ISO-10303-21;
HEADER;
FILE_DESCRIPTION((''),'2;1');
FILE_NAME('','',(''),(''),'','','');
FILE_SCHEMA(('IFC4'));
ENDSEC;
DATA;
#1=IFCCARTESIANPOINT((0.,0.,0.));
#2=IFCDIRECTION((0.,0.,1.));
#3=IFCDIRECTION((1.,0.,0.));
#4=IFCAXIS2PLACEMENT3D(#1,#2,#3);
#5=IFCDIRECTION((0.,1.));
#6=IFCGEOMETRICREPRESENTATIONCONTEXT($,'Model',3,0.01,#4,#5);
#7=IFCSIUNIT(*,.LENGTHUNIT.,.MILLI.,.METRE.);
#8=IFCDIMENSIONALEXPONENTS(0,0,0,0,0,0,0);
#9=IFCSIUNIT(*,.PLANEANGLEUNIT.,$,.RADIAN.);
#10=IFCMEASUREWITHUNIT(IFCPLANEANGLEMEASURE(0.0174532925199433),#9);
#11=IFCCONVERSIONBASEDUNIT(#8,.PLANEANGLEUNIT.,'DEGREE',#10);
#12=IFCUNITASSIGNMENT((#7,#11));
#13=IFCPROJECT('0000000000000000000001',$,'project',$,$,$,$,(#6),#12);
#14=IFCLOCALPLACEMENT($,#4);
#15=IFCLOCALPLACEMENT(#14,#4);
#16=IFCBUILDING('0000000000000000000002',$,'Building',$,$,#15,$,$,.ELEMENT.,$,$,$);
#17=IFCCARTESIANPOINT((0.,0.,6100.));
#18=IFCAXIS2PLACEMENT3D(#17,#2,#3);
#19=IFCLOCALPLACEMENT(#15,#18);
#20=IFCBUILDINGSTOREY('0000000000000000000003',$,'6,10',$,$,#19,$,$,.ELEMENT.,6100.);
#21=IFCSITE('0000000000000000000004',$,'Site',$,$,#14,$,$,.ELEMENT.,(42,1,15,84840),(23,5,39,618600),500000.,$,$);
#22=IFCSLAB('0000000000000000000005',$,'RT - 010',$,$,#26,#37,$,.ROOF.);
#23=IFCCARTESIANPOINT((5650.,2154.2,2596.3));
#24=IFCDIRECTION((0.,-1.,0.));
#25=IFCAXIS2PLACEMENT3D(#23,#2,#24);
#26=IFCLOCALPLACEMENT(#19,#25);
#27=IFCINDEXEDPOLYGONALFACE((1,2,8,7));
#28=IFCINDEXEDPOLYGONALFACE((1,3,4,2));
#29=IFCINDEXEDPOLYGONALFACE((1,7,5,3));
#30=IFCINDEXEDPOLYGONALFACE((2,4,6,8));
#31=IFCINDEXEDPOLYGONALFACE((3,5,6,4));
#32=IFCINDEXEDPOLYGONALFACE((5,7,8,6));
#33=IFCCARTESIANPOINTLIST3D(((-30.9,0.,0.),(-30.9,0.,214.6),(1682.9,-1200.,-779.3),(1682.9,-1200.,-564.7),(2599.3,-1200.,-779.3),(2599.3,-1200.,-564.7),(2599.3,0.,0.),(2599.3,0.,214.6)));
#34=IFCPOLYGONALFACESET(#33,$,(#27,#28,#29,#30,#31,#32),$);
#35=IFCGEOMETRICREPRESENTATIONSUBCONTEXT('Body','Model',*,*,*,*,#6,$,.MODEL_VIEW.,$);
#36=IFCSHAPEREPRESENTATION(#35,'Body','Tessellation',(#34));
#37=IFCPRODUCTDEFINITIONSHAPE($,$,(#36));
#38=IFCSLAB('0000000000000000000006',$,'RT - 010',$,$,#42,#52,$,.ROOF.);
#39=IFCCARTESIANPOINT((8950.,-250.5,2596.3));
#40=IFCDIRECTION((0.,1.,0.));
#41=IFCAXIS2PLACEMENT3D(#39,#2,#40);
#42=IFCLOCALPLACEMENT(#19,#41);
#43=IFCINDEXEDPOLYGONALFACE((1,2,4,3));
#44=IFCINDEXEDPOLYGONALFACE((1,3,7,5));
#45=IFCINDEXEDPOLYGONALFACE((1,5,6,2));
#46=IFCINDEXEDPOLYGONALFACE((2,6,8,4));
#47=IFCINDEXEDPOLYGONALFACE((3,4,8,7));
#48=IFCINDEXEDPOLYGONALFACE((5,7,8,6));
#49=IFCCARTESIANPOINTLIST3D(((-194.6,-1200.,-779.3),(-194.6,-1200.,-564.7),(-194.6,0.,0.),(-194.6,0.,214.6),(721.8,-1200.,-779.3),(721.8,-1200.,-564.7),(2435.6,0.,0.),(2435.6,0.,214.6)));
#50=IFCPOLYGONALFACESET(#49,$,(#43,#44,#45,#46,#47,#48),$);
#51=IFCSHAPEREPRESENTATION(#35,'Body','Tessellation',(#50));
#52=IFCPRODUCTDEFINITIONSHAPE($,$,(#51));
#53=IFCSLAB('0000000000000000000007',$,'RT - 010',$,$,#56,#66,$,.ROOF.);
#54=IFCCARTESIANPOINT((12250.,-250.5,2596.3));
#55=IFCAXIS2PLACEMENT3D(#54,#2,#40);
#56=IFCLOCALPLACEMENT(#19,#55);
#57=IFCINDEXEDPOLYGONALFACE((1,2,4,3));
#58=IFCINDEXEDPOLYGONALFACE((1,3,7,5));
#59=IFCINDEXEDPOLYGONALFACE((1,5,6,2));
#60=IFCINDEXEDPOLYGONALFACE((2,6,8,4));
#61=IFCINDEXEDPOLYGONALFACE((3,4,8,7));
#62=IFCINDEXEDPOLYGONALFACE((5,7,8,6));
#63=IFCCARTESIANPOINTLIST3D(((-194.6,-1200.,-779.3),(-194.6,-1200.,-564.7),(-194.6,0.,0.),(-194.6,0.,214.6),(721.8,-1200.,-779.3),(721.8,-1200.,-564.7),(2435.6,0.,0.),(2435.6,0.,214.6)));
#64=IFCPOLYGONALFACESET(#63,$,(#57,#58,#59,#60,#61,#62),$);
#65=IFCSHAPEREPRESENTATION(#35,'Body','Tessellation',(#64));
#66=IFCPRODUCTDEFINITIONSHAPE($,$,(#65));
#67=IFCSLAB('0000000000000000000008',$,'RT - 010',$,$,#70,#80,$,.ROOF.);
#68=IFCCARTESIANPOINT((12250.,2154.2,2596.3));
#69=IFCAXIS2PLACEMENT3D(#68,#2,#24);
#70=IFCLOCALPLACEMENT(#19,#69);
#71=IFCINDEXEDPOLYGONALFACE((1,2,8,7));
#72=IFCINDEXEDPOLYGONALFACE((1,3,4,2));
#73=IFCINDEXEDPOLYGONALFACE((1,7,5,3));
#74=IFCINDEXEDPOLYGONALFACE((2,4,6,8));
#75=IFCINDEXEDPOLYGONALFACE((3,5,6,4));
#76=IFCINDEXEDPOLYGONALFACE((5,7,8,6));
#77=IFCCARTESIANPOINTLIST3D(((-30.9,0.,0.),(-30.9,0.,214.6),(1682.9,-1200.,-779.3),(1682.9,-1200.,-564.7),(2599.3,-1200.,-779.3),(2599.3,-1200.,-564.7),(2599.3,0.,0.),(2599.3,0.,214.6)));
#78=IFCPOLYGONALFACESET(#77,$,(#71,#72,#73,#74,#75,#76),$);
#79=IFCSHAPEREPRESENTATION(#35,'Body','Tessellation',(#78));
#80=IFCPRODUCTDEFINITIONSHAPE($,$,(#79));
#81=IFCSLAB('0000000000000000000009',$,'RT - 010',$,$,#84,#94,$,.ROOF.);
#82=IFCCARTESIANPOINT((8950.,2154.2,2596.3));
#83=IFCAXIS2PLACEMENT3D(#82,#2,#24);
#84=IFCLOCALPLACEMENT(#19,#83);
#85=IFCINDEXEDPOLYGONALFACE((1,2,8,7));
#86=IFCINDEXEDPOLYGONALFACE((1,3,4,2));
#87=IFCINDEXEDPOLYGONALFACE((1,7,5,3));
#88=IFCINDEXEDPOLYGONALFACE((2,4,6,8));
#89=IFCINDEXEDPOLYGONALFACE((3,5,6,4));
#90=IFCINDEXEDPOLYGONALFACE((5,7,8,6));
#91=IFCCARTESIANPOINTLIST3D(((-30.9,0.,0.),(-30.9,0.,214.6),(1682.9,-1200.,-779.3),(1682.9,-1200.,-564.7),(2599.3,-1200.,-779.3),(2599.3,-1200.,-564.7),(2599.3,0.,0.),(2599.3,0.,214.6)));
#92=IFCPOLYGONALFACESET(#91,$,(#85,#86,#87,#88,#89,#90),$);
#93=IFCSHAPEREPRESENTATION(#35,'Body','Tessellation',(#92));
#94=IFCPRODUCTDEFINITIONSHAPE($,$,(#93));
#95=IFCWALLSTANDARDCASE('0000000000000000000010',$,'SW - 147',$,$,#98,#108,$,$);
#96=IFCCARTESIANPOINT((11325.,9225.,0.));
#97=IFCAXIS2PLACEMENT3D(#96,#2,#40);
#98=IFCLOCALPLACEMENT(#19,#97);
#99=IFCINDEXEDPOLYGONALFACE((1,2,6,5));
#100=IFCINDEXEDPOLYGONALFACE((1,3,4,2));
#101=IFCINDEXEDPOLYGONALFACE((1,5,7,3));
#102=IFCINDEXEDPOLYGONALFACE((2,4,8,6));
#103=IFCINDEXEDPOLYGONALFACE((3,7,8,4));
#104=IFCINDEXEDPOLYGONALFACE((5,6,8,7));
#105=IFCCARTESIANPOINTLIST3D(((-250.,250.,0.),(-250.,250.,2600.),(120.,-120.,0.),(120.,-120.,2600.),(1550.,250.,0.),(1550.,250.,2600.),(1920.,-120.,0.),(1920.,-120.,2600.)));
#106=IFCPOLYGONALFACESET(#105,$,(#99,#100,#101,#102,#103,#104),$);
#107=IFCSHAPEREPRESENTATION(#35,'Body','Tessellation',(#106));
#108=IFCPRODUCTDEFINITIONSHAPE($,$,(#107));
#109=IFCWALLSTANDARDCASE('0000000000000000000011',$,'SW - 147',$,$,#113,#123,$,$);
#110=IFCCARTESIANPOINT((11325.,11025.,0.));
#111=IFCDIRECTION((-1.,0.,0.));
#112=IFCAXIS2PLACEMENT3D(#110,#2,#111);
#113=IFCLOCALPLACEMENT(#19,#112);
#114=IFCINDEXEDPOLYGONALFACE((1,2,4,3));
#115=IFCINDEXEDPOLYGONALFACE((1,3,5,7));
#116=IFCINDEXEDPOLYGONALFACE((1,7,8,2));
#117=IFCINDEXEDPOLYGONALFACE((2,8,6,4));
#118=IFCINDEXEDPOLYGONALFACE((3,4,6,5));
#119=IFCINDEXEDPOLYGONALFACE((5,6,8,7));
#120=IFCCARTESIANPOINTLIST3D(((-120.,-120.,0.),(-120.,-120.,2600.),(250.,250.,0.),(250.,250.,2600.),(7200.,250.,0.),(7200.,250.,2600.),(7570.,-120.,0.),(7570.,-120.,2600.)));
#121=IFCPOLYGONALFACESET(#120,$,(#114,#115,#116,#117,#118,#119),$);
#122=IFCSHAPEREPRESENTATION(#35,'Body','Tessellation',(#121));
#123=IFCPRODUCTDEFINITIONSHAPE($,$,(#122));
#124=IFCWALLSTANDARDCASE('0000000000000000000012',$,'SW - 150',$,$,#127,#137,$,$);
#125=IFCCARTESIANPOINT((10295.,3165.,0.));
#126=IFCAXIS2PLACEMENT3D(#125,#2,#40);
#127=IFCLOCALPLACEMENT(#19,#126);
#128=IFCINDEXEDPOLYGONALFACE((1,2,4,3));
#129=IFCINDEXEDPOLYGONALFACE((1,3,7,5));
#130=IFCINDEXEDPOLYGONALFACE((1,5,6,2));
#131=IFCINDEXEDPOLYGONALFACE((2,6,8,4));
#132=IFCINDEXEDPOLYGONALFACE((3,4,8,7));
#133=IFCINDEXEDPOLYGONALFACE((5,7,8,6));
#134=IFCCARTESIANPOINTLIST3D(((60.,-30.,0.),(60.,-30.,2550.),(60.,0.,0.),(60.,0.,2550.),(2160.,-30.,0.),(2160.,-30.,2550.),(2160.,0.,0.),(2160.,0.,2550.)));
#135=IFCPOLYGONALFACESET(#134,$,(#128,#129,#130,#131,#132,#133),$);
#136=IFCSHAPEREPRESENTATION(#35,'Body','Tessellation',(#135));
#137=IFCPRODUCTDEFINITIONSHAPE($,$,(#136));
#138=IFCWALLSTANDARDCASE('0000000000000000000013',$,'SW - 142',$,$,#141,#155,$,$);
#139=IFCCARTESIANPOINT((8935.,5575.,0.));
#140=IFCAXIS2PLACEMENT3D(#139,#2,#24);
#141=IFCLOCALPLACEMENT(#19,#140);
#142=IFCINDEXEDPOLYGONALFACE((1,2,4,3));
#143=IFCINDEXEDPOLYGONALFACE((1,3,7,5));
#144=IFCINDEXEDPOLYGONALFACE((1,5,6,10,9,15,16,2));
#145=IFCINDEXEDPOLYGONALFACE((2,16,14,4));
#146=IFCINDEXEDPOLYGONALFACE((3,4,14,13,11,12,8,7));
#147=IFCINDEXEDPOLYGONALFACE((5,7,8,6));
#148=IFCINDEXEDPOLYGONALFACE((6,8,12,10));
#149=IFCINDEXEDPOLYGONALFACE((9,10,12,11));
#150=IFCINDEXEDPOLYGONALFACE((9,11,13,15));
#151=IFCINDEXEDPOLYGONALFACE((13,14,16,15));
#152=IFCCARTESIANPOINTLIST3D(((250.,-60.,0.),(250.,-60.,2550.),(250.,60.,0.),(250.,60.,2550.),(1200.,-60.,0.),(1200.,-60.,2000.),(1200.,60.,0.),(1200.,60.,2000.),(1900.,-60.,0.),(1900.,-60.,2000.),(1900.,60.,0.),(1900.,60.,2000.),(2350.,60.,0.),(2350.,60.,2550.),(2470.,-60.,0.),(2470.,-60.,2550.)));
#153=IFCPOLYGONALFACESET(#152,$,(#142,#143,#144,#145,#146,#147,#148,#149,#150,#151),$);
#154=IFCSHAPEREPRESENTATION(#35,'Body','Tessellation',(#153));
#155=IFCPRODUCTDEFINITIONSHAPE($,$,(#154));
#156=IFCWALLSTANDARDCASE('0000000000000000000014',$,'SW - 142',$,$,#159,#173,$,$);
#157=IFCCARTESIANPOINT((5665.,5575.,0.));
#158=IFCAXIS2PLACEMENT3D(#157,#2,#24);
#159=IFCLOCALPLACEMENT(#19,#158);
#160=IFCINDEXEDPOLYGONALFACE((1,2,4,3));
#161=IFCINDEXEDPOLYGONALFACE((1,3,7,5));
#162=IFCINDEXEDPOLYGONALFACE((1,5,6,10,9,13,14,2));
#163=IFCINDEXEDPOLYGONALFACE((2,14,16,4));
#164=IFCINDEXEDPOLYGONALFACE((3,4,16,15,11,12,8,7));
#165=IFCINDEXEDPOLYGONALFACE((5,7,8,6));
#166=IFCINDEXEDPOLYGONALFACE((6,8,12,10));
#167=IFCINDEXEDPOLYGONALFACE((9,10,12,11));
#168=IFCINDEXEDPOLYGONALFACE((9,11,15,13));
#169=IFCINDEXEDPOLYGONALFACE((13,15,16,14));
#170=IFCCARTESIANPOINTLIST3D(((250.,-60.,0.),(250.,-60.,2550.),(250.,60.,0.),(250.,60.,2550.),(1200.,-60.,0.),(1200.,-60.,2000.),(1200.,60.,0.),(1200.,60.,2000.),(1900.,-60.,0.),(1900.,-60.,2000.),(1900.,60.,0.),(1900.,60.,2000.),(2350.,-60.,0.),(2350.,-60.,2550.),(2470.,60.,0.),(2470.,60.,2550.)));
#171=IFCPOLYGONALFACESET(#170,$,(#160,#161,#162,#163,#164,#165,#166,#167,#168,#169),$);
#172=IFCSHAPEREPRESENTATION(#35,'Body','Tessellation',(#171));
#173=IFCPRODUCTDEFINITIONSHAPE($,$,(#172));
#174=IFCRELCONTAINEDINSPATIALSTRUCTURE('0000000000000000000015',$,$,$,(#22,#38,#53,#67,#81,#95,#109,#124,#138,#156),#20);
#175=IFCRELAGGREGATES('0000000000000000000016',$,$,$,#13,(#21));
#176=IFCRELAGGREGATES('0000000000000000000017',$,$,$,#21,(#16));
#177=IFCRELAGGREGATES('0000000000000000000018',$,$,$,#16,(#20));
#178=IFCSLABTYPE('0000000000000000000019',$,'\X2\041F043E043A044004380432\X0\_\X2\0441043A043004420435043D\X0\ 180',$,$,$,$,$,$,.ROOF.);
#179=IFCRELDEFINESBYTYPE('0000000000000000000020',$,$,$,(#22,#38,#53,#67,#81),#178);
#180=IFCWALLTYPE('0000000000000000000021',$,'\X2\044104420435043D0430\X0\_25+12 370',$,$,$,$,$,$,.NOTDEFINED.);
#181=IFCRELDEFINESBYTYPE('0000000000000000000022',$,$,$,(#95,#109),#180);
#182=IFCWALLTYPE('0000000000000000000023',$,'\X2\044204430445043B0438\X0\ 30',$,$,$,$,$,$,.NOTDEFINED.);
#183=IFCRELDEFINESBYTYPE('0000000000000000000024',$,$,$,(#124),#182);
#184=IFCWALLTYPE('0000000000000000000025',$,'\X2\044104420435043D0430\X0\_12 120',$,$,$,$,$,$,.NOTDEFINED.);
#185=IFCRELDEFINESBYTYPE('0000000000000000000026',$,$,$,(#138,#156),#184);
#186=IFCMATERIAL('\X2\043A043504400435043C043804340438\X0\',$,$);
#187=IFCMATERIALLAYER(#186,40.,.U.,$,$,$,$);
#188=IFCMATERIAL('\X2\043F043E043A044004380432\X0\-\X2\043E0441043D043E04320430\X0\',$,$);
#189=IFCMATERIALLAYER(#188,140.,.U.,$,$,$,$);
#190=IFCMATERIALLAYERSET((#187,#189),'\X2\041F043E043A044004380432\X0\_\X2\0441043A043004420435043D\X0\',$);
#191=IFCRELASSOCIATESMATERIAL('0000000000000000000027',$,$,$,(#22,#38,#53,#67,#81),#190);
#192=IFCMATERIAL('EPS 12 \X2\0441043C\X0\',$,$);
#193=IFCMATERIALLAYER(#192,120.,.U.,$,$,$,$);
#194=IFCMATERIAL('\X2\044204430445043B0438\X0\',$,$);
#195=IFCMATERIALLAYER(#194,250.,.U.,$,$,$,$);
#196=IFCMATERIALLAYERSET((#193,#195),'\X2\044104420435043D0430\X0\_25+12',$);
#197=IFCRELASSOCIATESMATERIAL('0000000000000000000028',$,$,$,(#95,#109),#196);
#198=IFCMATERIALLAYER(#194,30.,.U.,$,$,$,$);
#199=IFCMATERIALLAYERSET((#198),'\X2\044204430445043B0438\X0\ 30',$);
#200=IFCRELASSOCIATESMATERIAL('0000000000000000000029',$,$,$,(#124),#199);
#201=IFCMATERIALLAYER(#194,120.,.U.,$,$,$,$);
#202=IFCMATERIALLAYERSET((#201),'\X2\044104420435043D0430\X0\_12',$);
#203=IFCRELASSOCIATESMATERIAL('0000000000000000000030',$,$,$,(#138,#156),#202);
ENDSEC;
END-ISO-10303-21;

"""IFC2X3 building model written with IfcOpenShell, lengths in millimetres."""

from ifc_helpers import new_model, entity, si_unit, converted_unit, direction, frame, origin_with_axes, origin_2d_with_axis, place, context, subcontext, project, spatial, polyline, rectangle, outline, extrude, material, layer, layer_set, layer_usage, type_object, element, save


model = new_model("IFC2X3")

# Units and contexts
model_context = context("Model", 3, precision=0.01, world=origin_with_axes(), true_north=direction((0.0, 1.0)))
body_context = subcontext(model_context, "Body", "Model", "MODEL_VIEW")
ifc_project = project(units=[si_unit("LENGTHUNIT", "METRE", prefix="MILLI"), converted_unit("PLANEANGLEUNIT", "DEGREE", entity("IfcPlaneAngleMeasure", 0.0174532925199433), si_unit("PLANEANGLEUNIT", "RADIAN"), dimensions=[0, 0, 0, 0, 0, 0, 0])], contexts=[model_context])

# Site, building, storey
site_placement = place(None, origin_with_axes())
site = spatial("IfcSite", under=ifc_project, at=site_placement, Name="Site", CompositionType="ELEMENT", RefLatitude=(42, 1, 15, 84840), RefLongitude=(23, 5, 39, 618600), RefElevation=500000.0)
building_placement = place(site_placement, origin_with_axes())
building = spatial("IfcBuilding", under=site, at=building_placement, Name="Building", CompositionType="ELEMENT")
storey_placement = place(building_placement, frame((0.0, 0.0, 6100.0), z_axis=(0.0, 0.0, 1.0), x_axis=(1.0, 0.0, 0.0)))
storey = spatial("IfcBuildingStorey", under=building, at=storey_placement, Name="6,10", CompositionType="ELEMENT", Elevation=6100.0)

# Slabs
ifc_material_1 = material(Name="керемиди")
ifc_layer_1 = layer(ifc_material_1, 40.0, ventilated="UNKNOWN")
ifc_material_2 = material(Name="покрив-основа")
ifc_layer_2 = layer(ifc_material_2, 140.0, ventilated="UNKNOWN")
ifc_layer_set_1 = layer_set([ifc_layer_1, ifc_layer_2], Name="Покрив_скатен")
ifc_layer_usage_1 = layer_usage(ifc_layer_set_1, "AXIS3", "NEGATIVE", 180.0)
slab_type = type_object("IfcSlabType", Name="Покрив_скатен 180", PredefinedType="ROOF")
slab_1_placement = place(storey_placement, frame((5650.0, 2154.2, 2596.3), z_axis=(0.0, 0.0, 1.0), x_axis=(0.0, -1.0, 0.0)))
element("IfcSlab", 1, at=slab_1_placement, inside=storey, type_object=slab_type, material=ifc_layer_usage_1, Name="RT - 010", PredefinedType="ROOF", context=body_context, shape_type="SweptSolid", body=[
    extrude(outline(polyline([(-30.9, 0.0), (1682.9, -1430.8), (2599.3, -1430.8), (2599.3, 0.0), (-30.9, 0.0)])), frame((0.0, 0.0, 0.0), z_axis=(0.0, -0.544639, 0.838671), x_axis=(1.0, 0.0, 0.0)), (0.0, 0.544639, 0.838671), 214.6),
])
ifc_layer_usage_2 = layer_usage(ifc_layer_set_1, "AXIS3", "NEGATIVE", 180.0)
slab_2_placement = place(storey_placement, frame((8950.0, -250.5, 2596.3), z_axis=(0.0, 0.0, 1.0), x_axis=(0.0, 1.0, 0.0)))
element("IfcSlab", 2, at=slab_2_placement, inside=storey, type_object=slab_type, material=ifc_layer_usage_2, Name="RT - 010", PredefinedType="ROOF", context=body_context, shape_type="SweptSolid", body=[
    extrude(outline(polyline([(2435.6, 0.0), (-194.6, 0.0), (-194.6, -1430.8), (721.8, -1430.8), (2435.6, 0.0)])), frame((0.0, 0.0, 0.0), z_axis=(0.0, -0.544639, 0.838671), x_axis=(1.0, 0.0, 0.0)), (0.0, 0.544639, 0.838671), 214.6),
])
ifc_layer_usage_3 = layer_usage(ifc_layer_set_1, "AXIS3", "NEGATIVE", 180.0)
slab_3_placement = place(storey_placement, frame((12250.0, -250.5, 2596.3), z_axis=(0.0, 0.0, 1.0), x_axis=(0.0, 1.0, 0.0)))
element("IfcSlab", 3, at=slab_3_placement, inside=storey, type_object=slab_type, material=ifc_layer_usage_3, Name="RT - 010", PredefinedType="ROOF", context=body_context, shape_type="SweptSolid", body=[
    extrude(outline(polyline([(2435.6, 0.0), (-194.6, 0.0), (-194.6, -1430.8), (721.8, -1430.8), (2435.6, 0.0)])), frame((0.0, 0.0, 0.0), z_axis=(0.0, -0.544639, 0.838671), x_axis=(1.0, 0.0, 0.0)), (0.0, 0.544639, 0.838671), 214.6),
])
ifc_layer_usage_4 = layer_usage(ifc_layer_set_1, "AXIS3", "NEGATIVE", 180.0)
slab_4_placement = place(storey_placement, frame((12250.0, 2154.2, 2596.3), z_axis=(0.0, 0.0, 1.0), x_axis=(0.0, -1.0, 0.0)))
element("IfcSlab", 4, at=slab_4_placement, inside=storey, type_object=slab_type, material=ifc_layer_usage_4, Name="RT - 010", PredefinedType="ROOF", context=body_context, shape_type="SweptSolid", body=[
    extrude(outline(polyline([(-30.9, 0.0), (1682.9, -1430.8), (2599.3, -1430.8), (2599.3, 0.0), (-30.9, 0.0)])), frame((0.0, 0.0, 0.0), z_axis=(0.0, -0.544639, 0.838671), x_axis=(1.0, 0.0, 0.0)), (0.0, 0.544639, 0.838671), 214.6),
])
ifc_layer_usage_5 = layer_usage(ifc_layer_set_1, "AXIS3", "NEGATIVE", 180.0)
slab_5_placement = place(storey_placement, frame((8950.0, 2154.2, 2596.3), z_axis=(0.0, 0.0, 1.0), x_axis=(0.0, -1.0, 0.0)))
element("IfcSlab", 5, at=slab_5_placement, inside=storey, type_object=slab_type, material=ifc_layer_usage_5, Name="RT - 010", PredefinedType="ROOF", context=body_context, shape_type="SweptSolid", body=[
    extrude(outline(polyline([(-30.9, 0.0), (1682.9, -1430.8), (2599.3, -1430.8), (2599.3, 0.0), (-30.9, 0.0)])), frame((0.0, 0.0, 0.0), z_axis=(0.0, -0.544639, 0.838671), x_axis=(1.0, 0.0, 0.0)), (0.0, 0.544639, 0.838671), 214.6),
])

# Shared definitions
ifc_material_3 = material(Name="EPS 12 см")
ifc_layer_3 = layer(ifc_material_3, 120.0, ventilated="UNKNOWN")
ifc_material_4 = material(Name="тухли")
ifc_layer_4 = layer(ifc_material_4, 250.0, ventilated="UNKNOWN")
ifc_layer_set_2 = layer_set([ifc_layer_3, ifc_layer_4], Name="стена_25+12")
wall_type_1 = type_object("IfcWallType", Name="стена_25+12 370", PredefinedType="NOTDEFINED")

# Walls
ifc_layer_usage_6 = layer_usage(ifc_layer_set_2, "AXIS2", "POSITIVE", -120.0)
wall_1_placement = place(storey_placement, frame((11325.0, 9225.0, 0.0), z_axis=(0.0, 0.0, 1.0), x_axis=(0.0, 1.0, 0.0)))
element("IfcWallStandardCase", 6, at=wall_1_placement, inside=storey, type_object=wall_type_1, material=ifc_layer_usage_6, Name="SW - 147", context=body_context, shape_type="SweptSolid", body=[
    extrude(outline(polyline([(120.0, -120.0), (1920.0, -120.0), (1550.0, 250.0), (-250.0, 250.0), (120.0, -120.0)])), origin_with_axes(), (0.0, 0.0, 1.0), 2600.0),
])
ifc_layer_usage_7 = layer_usage(ifc_layer_set_2, "AXIS2", "POSITIVE", -120.0)
wall_2_placement = place(storey_placement, frame((11325.0, 11025.0, 0.0), z_axis=(0.0, 0.0, 1.0), x_axis=(-1.0, 0.0, 0.0)))
element("IfcWallStandardCase", 7, at=wall_2_placement, inside=storey, type_object=wall_type_1, material=ifc_layer_usage_7, Name="SW - 147", context=body_context, shape_type="SweptSolid", body=[
    extrude(outline(polyline([(-120.0, -120.0), (7570.0, -120.0), (7200.0, 250.0), (250.0, 250.0), (-120.0, -120.0)])), origin_with_axes(), (0.0, 0.0, 1.0), 2600.0),
])
ifc_layer_5 = layer(ifc_material_4, 30.0, ventilated="UNKNOWN")
ifc_layer_set_3 = layer_set([ifc_layer_5], Name="тухли 30")
ifc_layer_usage_8 = layer_usage(ifc_layer_set_3, "AXIS2", "NEGATIVE", 0.0)
wall_type_2 = type_object("IfcWallType", Name="тухли 30", PredefinedType="NOTDEFINED")
wall_3_placement = place(storey_placement, frame((10295.0, 3165.0, 0.0), z_axis=(0.0, 0.0, 1.0), x_axis=(0.0, 1.0, 0.0)))
element("IfcWallStandardCase", 8, at=wall_3_placement, inside=storey, type_object=wall_type_2, material=ifc_layer_usage_8, Name="SW - 150", context=body_context, shape_type="SweptSolid", body=[
    extrude(outline(polyline([(60.0, -30.0), (2160.0, -30.0), (2160.0, 0.0), (60.0, 0.0), (60.0, -30.0)])), origin_with_axes(), (0.0, 0.0, 1.0), 2550.0),
])

# Shared definitions
ifc_layer_6 = layer(ifc_material_4, 120.0, ventilated="UNKNOWN")
ifc_layer_set_4 = layer_set([ifc_layer_6], Name="стена_12")
wall_type_3 = type_object("IfcWallType", Name="стена_12 120", PredefinedType="NOTDEFINED")

# Wall, opening
ifc_layer_usage_9 = layer_usage(ifc_layer_set_4, "AXIS2", "POSITIVE", -60.0)
wall_4_placement = place(storey_placement, frame((8935.0, 5575.0, 0.0), z_axis=(0.0, 0.0, 1.0), x_axis=(0.0, -1.0, 0.0)))
wall_4 = element("IfcWallStandardCase", 9, at=wall_4_placement, inside=storey, type_object=wall_type_3, material=ifc_layer_usage_9, Name="SW - 142", context=body_context, shape_type="SweptSolid", body=[
    extrude(outline(polyline([(250.0, -60.0), (2470.0, -60.0), (2350.0, 60.0), (250.0, 60.0), (250.0, -60.0)])), origin_with_axes(), (0.0, 0.0, 1.0), 2550.0),
])
opening_1_placement = place(wall_4_placement, frame((1550.0, 0.0, 0.0), z_axis=(0.0, 0.0, 1.0), x_axis=(1.0, 0.0, 0.0)))
element("IfcOpeningElement", 10, at=opening_1_placement, cuts=wall_4, context=body_context, shape_type="SweptSolid", body=[
    extrude(rectangle(XDim=700.0, YDim=2000.0, at=origin_2d_with_axis()), frame((0.0, -120.0, 1000.0), z_axis=(0.0, -1.0, 0.0), x_axis=(-1.0, 0.0, 0.0)), (0.0, 0.0, -1.0), 360.0),
])

# Wall, opening
ifc_layer_usage_10 = layer_usage(ifc_layer_set_4, "AXIS2", "NEGATIVE", 60.0)
wall_5_placement = place(storey_placement, frame((5665.0, 5575.0, 0.0), z_axis=(0.0, 0.0, 1.0), x_axis=(0.0, -1.0, 0.0)))
wall_5 = element("IfcWallStandardCase", 11, at=wall_5_placement, inside=storey, type_object=wall_type_3, material=ifc_layer_usage_10, Name="SW - 142", context=body_context, shape_type="SweptSolid", body=[
    extrude(outline(polyline([(250.0, -60.0), (2350.0, -60.0), (2470.0, 60.0), (250.0, 60.0), (250.0, -60.0)])), origin_with_axes(), (0.0, 0.0, 1.0), 2550.0),
])
opening_2_placement = place(wall_5_placement, frame((1550.0, 0.0, 0.0), z_axis=(0.0, 0.0, 1.0), x_axis=(1.0, 0.0, 0.0)))
element("IfcOpeningElement", 12, at=opening_2_placement, cuts=wall_5, context=body_context, shape_type="SweptSolid", body=[
    extrude(rectangle(XDim=700.0, YDim=2000.0, at=origin_2d_with_axis()), frame((0.0, 120.0, 1000.0), z_axis=(0.0, -1.0, 0.0), x_axis=(-1.0, 0.0, 0.0)), (0.0, 0.0, 1.0), 360.0),
])

save(model, "model.ifc")
